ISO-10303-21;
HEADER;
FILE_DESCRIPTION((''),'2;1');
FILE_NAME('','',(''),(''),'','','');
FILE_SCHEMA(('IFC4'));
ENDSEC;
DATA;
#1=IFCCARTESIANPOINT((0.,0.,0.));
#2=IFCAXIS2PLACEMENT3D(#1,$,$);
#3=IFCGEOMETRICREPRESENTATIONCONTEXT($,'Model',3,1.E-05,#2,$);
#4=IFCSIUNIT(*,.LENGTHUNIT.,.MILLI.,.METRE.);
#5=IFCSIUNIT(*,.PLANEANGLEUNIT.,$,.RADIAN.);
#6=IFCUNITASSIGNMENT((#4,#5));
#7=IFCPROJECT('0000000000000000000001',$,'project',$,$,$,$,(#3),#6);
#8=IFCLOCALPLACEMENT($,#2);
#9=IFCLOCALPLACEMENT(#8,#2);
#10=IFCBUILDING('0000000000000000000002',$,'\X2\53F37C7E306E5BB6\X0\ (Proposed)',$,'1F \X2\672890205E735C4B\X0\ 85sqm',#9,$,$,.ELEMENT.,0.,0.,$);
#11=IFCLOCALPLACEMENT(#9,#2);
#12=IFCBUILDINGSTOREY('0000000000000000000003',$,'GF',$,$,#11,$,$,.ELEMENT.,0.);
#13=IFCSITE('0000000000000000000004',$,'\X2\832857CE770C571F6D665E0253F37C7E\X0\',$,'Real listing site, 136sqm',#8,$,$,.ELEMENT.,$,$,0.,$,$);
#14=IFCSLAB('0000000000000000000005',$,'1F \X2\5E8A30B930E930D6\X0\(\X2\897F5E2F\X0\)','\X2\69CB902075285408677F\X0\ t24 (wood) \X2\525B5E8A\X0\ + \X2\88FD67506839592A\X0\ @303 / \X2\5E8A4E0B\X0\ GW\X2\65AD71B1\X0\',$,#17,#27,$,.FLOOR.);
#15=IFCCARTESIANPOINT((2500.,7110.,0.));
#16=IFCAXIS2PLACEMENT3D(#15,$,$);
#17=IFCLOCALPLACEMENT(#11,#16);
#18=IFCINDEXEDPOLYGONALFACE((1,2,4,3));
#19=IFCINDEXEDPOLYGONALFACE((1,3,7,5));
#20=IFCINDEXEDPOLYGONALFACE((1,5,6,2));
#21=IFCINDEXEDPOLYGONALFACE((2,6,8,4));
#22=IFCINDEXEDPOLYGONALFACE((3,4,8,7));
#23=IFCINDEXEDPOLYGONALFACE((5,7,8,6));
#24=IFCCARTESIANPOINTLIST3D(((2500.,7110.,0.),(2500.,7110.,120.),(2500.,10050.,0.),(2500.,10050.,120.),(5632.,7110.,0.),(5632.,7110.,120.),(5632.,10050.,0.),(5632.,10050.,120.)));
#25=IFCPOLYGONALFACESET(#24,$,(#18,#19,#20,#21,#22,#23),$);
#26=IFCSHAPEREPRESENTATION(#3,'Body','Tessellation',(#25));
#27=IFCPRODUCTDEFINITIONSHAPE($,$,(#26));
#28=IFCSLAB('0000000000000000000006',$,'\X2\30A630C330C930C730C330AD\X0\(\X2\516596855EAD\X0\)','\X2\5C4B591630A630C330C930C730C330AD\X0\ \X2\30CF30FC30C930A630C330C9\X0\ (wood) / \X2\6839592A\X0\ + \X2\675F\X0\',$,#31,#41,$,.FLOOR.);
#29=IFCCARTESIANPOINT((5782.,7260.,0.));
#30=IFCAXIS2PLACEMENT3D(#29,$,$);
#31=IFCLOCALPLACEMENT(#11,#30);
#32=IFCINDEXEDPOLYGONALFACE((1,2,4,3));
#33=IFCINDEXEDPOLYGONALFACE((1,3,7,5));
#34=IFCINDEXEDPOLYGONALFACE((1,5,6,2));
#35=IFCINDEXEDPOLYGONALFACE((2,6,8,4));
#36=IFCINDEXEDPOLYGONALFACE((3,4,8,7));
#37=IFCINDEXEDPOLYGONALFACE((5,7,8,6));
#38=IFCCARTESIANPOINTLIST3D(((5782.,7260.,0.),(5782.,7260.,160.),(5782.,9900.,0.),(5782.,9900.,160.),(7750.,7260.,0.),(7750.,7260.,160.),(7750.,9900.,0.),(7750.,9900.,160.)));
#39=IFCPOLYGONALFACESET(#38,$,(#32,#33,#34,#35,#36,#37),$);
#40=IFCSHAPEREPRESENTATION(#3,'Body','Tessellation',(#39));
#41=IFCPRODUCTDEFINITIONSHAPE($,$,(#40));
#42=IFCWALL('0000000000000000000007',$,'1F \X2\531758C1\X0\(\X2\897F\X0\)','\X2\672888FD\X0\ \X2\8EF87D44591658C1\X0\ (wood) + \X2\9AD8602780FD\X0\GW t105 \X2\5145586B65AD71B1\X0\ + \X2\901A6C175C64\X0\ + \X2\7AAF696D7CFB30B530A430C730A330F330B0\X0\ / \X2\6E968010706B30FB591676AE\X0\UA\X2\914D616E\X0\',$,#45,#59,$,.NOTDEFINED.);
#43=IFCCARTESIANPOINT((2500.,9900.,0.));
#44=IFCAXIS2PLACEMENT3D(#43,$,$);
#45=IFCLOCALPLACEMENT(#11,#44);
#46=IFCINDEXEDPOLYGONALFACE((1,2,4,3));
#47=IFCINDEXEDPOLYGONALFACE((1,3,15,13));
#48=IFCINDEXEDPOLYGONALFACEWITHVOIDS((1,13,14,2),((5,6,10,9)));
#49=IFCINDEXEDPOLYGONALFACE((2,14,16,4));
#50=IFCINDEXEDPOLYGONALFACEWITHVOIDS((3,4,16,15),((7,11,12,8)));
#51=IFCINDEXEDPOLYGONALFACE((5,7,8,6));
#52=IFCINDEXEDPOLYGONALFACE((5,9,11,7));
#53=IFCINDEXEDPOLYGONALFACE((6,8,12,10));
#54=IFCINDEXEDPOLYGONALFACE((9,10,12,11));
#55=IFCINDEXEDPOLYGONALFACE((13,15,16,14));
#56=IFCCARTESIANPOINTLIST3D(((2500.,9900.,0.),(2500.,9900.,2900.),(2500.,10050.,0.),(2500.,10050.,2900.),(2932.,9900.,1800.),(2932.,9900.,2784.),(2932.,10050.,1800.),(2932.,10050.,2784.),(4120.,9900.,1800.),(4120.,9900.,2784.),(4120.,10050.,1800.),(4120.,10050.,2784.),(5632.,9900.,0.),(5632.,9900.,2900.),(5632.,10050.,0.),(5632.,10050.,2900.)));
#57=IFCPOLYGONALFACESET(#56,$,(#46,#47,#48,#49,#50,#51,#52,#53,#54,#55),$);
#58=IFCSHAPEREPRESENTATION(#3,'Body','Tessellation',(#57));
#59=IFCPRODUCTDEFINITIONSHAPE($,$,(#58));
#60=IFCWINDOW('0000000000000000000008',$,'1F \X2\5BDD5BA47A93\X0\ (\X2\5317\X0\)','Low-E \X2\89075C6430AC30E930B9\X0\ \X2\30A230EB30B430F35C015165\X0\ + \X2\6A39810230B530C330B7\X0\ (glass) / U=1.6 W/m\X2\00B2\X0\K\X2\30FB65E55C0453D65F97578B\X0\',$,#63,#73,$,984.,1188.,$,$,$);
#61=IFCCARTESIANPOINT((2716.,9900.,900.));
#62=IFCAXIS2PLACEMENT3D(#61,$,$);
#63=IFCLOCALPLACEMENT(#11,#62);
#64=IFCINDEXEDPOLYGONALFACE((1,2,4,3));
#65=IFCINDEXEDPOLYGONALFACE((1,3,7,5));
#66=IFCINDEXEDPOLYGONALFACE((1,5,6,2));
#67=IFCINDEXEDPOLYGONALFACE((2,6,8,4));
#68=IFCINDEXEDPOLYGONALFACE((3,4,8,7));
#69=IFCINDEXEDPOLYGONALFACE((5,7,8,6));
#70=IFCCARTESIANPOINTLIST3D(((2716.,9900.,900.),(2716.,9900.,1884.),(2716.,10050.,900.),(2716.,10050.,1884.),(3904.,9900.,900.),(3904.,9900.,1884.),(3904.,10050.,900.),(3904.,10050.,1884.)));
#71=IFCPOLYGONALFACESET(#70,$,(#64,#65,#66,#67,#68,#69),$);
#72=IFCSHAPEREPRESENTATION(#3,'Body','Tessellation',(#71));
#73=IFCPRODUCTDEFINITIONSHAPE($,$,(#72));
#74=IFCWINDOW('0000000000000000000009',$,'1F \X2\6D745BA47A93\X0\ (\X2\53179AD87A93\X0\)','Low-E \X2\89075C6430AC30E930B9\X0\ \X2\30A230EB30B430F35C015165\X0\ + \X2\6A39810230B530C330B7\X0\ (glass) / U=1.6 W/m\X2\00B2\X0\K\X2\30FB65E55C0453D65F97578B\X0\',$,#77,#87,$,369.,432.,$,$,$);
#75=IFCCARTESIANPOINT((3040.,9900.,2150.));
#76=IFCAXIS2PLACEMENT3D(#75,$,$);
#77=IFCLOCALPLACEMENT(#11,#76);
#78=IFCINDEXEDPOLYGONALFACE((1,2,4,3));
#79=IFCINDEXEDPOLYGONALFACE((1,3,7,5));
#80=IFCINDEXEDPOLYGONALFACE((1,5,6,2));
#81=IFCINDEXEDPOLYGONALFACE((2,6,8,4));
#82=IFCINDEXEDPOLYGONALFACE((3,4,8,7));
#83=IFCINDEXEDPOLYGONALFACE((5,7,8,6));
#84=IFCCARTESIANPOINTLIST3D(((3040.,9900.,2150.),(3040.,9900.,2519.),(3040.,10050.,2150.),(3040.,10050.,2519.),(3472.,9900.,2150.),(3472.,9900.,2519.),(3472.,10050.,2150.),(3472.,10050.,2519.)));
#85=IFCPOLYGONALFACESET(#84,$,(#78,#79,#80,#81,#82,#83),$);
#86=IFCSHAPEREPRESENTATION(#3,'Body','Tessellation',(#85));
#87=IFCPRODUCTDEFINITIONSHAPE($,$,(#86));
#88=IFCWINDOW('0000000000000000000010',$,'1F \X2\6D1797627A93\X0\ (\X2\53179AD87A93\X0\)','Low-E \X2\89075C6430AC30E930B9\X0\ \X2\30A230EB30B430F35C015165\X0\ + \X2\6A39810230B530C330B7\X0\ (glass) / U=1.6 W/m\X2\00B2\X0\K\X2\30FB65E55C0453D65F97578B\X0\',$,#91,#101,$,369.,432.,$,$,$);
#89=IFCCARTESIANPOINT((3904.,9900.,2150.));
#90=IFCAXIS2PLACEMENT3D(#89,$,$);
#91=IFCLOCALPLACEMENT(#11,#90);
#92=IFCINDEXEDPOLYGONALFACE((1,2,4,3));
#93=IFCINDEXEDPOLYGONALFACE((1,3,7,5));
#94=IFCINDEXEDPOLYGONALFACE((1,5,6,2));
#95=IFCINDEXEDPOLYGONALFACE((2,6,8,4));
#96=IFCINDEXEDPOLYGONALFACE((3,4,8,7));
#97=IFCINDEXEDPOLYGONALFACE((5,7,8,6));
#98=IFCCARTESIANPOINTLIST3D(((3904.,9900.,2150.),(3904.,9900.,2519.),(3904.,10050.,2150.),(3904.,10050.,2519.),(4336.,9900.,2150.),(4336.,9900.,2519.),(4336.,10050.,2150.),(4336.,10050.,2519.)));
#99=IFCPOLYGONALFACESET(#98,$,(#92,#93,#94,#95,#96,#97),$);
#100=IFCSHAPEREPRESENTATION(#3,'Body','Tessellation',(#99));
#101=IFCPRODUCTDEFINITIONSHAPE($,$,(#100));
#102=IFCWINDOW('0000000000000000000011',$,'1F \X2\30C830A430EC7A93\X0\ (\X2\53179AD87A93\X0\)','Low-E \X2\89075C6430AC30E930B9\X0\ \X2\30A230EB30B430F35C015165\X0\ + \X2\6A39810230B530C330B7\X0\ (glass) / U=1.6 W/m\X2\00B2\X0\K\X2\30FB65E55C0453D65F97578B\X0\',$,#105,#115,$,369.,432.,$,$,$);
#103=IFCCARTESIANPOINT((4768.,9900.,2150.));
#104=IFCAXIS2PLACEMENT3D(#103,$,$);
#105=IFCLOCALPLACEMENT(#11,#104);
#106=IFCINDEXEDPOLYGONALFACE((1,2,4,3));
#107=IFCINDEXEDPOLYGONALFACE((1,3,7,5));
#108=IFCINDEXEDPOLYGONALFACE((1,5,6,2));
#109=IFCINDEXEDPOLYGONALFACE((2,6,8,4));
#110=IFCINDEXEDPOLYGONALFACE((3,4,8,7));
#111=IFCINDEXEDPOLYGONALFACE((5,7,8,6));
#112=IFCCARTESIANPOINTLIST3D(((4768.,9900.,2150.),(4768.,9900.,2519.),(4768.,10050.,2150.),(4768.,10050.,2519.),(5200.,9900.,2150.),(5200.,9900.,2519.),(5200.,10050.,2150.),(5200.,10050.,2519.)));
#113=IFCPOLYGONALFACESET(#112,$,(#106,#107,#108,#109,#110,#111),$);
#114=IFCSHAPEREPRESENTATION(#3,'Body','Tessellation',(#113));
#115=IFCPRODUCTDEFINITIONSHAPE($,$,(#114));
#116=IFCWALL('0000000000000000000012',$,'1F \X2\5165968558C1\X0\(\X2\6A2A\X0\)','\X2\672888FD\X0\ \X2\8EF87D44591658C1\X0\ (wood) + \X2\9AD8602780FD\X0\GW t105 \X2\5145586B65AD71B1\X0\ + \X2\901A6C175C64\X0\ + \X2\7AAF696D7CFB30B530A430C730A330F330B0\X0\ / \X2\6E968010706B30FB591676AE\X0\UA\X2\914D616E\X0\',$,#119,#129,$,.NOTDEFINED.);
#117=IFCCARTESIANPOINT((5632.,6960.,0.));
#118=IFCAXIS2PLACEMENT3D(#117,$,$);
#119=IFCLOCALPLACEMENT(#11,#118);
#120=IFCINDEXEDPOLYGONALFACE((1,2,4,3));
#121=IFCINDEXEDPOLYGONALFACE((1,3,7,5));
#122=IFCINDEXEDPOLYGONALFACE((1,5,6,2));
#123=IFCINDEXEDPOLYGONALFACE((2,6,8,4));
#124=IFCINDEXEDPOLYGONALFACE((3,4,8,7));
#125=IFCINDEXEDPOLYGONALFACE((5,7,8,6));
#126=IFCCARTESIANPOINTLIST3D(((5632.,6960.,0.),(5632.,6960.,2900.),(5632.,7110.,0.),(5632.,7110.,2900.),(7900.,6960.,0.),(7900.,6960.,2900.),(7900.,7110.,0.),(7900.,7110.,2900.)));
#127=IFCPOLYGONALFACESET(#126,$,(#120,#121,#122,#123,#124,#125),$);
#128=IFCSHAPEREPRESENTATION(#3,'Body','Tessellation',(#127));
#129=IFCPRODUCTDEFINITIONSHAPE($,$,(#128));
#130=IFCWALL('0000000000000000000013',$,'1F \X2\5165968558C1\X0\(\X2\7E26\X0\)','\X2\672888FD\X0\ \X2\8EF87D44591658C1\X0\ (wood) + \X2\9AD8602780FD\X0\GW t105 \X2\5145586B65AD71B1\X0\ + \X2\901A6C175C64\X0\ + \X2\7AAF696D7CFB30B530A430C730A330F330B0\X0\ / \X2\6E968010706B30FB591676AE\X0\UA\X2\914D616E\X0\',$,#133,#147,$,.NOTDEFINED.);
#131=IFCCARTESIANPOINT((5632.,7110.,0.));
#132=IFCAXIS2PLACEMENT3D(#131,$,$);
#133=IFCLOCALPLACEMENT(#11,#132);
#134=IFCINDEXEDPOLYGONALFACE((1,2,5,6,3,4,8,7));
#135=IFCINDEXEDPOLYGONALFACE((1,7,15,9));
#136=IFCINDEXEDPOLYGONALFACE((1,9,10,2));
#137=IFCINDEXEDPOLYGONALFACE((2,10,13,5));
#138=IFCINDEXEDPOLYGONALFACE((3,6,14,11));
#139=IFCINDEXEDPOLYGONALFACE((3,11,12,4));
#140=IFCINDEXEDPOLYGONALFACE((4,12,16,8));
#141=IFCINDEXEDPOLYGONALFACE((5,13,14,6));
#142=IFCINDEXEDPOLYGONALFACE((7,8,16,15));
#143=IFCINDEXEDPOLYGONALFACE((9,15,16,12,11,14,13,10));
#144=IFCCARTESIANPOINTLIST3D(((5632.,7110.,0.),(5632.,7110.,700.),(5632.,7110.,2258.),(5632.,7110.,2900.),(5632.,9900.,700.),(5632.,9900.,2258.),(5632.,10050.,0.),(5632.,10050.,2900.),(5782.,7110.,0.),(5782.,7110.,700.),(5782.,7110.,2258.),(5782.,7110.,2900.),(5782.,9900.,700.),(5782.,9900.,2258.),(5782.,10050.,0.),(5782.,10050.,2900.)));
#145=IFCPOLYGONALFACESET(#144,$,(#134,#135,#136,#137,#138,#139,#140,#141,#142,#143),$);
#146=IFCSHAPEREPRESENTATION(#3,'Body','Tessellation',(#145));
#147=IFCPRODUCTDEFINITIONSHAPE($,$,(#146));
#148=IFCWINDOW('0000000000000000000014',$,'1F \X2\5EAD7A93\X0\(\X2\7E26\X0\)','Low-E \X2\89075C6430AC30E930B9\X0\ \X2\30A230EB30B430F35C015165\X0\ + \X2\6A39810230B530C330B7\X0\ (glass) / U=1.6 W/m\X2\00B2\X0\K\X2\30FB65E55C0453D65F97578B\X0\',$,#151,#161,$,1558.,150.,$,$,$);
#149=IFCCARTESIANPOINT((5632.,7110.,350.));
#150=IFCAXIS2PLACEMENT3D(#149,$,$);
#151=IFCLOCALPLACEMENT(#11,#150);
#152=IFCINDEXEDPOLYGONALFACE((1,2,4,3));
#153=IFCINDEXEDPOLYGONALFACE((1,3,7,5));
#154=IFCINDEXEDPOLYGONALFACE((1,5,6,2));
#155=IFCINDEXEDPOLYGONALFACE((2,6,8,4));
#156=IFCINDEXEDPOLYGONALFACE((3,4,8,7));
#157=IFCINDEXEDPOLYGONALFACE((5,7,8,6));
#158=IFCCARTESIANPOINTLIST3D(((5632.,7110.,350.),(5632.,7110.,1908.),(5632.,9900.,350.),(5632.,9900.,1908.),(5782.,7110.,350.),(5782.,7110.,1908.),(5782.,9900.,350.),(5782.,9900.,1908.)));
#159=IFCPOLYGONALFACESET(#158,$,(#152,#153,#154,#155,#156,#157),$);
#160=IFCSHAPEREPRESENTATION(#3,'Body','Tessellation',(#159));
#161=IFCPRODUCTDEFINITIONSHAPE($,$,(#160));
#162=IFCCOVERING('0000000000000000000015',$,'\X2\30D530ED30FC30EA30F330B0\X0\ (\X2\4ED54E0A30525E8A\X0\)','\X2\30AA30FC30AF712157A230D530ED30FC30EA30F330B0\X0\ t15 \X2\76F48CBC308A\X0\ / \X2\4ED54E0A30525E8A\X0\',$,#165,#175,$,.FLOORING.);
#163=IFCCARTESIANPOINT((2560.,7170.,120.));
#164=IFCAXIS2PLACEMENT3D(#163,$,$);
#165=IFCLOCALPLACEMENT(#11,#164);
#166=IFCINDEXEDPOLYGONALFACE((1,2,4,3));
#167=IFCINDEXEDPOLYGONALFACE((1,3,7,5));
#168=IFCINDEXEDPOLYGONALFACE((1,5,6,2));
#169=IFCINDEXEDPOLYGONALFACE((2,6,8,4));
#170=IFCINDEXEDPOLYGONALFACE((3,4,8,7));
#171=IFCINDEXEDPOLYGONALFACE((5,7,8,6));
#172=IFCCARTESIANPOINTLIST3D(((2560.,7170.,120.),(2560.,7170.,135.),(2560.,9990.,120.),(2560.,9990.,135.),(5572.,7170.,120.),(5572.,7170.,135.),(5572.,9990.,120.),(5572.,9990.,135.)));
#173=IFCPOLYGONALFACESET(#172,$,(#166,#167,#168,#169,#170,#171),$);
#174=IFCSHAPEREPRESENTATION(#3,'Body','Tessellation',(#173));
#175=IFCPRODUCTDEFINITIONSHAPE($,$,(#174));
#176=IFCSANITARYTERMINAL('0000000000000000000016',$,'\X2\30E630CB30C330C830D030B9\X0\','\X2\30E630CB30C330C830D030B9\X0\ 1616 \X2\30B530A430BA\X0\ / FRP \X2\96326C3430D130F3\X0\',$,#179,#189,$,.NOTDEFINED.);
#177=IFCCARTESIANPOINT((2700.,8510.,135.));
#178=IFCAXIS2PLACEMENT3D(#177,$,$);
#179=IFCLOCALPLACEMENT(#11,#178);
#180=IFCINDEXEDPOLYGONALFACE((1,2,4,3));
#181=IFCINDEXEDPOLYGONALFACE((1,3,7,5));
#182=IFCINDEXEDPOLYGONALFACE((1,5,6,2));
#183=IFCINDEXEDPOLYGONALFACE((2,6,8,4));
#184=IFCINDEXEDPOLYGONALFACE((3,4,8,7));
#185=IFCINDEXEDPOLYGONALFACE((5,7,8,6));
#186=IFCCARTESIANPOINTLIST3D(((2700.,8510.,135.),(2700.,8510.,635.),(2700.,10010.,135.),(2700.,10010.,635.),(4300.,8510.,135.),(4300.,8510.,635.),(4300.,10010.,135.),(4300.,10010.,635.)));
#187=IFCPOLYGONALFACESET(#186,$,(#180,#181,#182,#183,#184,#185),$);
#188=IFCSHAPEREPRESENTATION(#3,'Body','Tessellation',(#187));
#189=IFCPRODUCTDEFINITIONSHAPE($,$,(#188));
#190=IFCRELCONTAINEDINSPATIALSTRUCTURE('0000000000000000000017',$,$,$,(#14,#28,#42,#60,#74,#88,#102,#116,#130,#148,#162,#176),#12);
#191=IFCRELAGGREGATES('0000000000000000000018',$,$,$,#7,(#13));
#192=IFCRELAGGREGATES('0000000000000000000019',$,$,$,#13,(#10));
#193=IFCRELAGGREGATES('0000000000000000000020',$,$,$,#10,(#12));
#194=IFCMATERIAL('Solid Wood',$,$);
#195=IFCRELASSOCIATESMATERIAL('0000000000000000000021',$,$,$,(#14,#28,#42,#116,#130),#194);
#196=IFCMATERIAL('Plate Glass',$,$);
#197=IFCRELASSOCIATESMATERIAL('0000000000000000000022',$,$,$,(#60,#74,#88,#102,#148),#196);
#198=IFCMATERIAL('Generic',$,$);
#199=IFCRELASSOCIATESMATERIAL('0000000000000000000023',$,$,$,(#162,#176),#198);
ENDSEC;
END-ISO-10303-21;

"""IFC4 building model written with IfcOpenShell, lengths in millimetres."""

from ifc_helpers import new_model, si_unit, frame, frame_2d, origin, place, context, project, spatial, rectangle, extrude, material, element, fill, save


model = new_model("IFC4")

# Units and contexts
model_context = context("Model", 3, precision=1e-05, world=origin())
ifc_project = project(units=[si_unit("LENGTHUNIT", "METRE", prefix="MILLI"), si_unit("PLANEANGLEUNIT", "RADIAN")], contexts=[model_context])

# Site, building, storey
site_placement = place(None, origin())
site = spatial("IfcSite", under=ifc_project, at=site_placement, Name="茨城県土浦市右籾", ObjectType="Real listing site, 136sqm", CompositionType="ELEMENT", RefElevation=0.0)
building_placement = place(site_placement, origin())
building = spatial("IfcBuilding", under=site, at=building_placement, Name="右籾の家 (Proposed)", ObjectType="1F 木造平屋 85sqm", CompositionType="ELEMENT", ElevationOfRefHeight=0.0, ElevationOfTerrain=0.0)
storey_placement = place(building_placement, origin())
storey = spatial("IfcBuildingStorey", under=building, at=storey_placement, Name="GF", CompositionType="ELEMENT", Elevation=0.0)

# Slabs
ifc_material_1 = material(Name="Solid Wood")
slab_1_placement = place(storey_placement, frame((2500.0, 7110.0, 0.0)))
element("IfcSlab", 1, at=slab_1_placement, inside=storey, material=ifc_material_1, Name="1F 床スラブ(西帯)", Description="構造用合板 t24 (wood) 剛床 + 製材根太 @303 / 床下 GW断熱", PredefinedType="FLOOR", context=model_context, shape_type="SweptSolid", body=[
    extrude(rectangle(XDim=3132.0, YDim=2940.0, at=frame_2d((1566.0, 1470.0))), frame((2500.0, 7110.0, 0.0)), (0.0, 0.0, 1.0), 120.0),
])
slab_2_placement = place(storey_placement, frame((5782.0, 7260.0, 0.0)))
element("IfcSlab", 2, at=slab_2_placement, inside=storey, material=ifc_material_1, Name="ウッドデッキ(入隅庭)", Description="屋外ウッドデッキ ハードウッド (wood) / 根太 + 束", PredefinedType="FLOOR", context=model_context, shape_type="SweptSolid", body=[
    extrude(rectangle(XDim=1968.0, YDim=2640.0, at=frame_2d((984.0, 1320.0))), frame((5782.0, 7260.0, 0.0)), (0.0, 0.0, 1.0), 160.0),
])

# Wall, openings, windows
wall_1_placement = place(storey_placement, frame((2500.0, 9900.0, 0.0)))
wall_1 = element("IfcWall", 3, at=wall_1_placement, inside=storey, material=ifc_material_1, Name="1F 北壁(西)", Description="木製 軸組外壁 (wood) + 高性能GW t105 充填断熱 + 通気層 + 窯業系サイディング / 準耐火・外皮UA配慮", PredefinedType="NOTDEFINED", context=model_context, shape_type="SweptSolid", body=[
    extrude(rectangle(XDim=3132.0, YDim=150.0, at=frame_2d((1566.0, 75.0))), frame((2500.0, 9900.0, 0.0)), (0.0, 0.0, 1.0), 2900.0),
])
opening_1_placement = place(storey_placement, frame((2716.0, 9900.0, 900.0)))
opening_1 = element("IfcOpeningElement", 4, at=opening_1_placement, cuts=wall_1, PredefinedType="NOTDEFINED", context=model_context, shape_type="SweptSolid", body=[
    extrude(rectangle(XDim=1188.0, YDim=150.0, at=frame_2d((594.0, 75.0))), frame((2716.0, 9900.0, 900.0)), (0.0, 0.0, 1.0), 984.0),
])
opening_2_placement = place(storey_placement, frame((3040.0, 9900.0, 2150.0)))
opening_2 = element("IfcOpeningElement", 5, at=opening_2_placement, cuts=wall_1, PredefinedType="NOTDEFINED", context=model_context, shape_type="SweptSolid", body=[
    extrude(rectangle(XDim=432.0, YDim=150.0, at=frame_2d((216.0, 75.0))), frame((3040.0, 9900.0, 2150.0)), (0.0, 0.0, 1.0), 369.0),
])
opening_3_placement = place(storey_placement, frame((3904.0, 9900.0, 2150.0)))
opening_3 = element("IfcOpeningElement", 6, at=opening_3_placement, cuts=wall_1, PredefinedType="NOTDEFINED", context=model_context, shape_type="SweptSolid", body=[
    extrude(rectangle(XDim=432.0, YDim=150.0, at=frame_2d((216.0, 75.0))), frame((3904.0, 9900.0, 2150.0)), (0.0, 0.0, 1.0), 369.0),
])
opening_4_placement = place(storey_placement, frame((4768.0, 9900.0, 2150.0)))
opening_4 = element("IfcOpeningElement", 7, at=opening_4_placement, cuts=wall_1, PredefinedType="NOTDEFINED", context=model_context, shape_type="SweptSolid", body=[
    extrude(rectangle(XDim=432.0, YDim=150.0, at=frame_2d((216.0, 75.0))), frame((4768.0, 9900.0, 2150.0)), (0.0, 0.0, 1.0), 369.0),
])
ifc_material_2 = material(Name="Plate Glass")
window_1_placement = place(storey_placement, frame((2716.0, 9900.0, 900.0)))
window_1 = element("IfcWindow", 8, at=window_1_placement, inside=storey, material=ifc_material_2, Name="1F 寝室窓 (北)", Description="Low-E 複層ガラス アルゴン封入 + 樹脂サッシ (glass) / U=1.6 W/m²K・日射取得型", OverallHeight=984.0, OverallWidth=1188.0, context=model_context, shape_type="SweptSolid", body=[
    extrude(rectangle(XDim=1188.0, YDim=150.0, at=frame_2d((594.0, 75.0))), frame((2716.0, 9900.0, 900.0)), (0.0, 0.0, 1.0), 984.0),
])
fill(opening_1, window_1)
window_2_placement = place(storey_placement, frame((3040.0, 9900.0, 2150.0)))
window_2 = element("IfcWindow", 9, at=window_2_placement, inside=storey, material=ifc_material_2, Name="1F 浴室窓 (北高窓)", Description="Low-E 複層ガラス アルゴン封入 + 樹脂サッシ (glass) / U=1.6 W/m²K・日射取得型", OverallHeight=369.0, OverallWidth=432.0, context=model_context, shape_type="SweptSolid", body=[
    extrude(rectangle(XDim=432.0, YDim=150.0, at=frame_2d((216.0, 75.0))), frame((3040.0, 9900.0, 2150.0)), (0.0, 0.0, 1.0), 369.0),
])
fill(opening_2, window_2)
window_3_placement = place(storey_placement, frame((3904.0, 9900.0, 2150.0)))
window_3 = element("IfcWindow", 10, at=window_3_placement, inside=storey, material=ifc_material_2, Name="1F 洗面窓 (北高窓)", Description="Low-E 複層ガラス アルゴン封入 + 樹脂サッシ (glass) / U=1.6 W/m²K・日射取得型", OverallHeight=369.0, OverallWidth=432.0, context=model_context, shape_type="SweptSolid", body=[
    extrude(rectangle(XDim=432.0, YDim=150.0, at=frame_2d((216.0, 75.0))), frame((3904.0, 9900.0, 2150.0)), (0.0, 0.0, 1.0), 369.0),
])
fill(opening_3, window_3)
window_4_placement = place(storey_placement, frame((4768.0, 9900.0, 2150.0)))
window_4 = element("IfcWindow", 11, at=window_4_placement, inside=storey, material=ifc_material_2, Name="1F トイレ窓 (北高窓)", Description="Low-E 複層ガラス アルゴン封入 + 樹脂サッシ (glass) / U=1.6 W/m²K・日射取得型", OverallHeight=369.0, OverallWidth=432.0, context=model_context, shape_type="SweptSolid", body=[
    extrude(rectangle(XDim=432.0, YDim=150.0, at=frame_2d((216.0, 75.0))), frame((4768.0, 9900.0, 2150.0)), (0.0, 0.0, 1.0), 369.0),
])
fill(opening_4, window_4)

# Wall
wall_2_placement = place(storey_placement, frame((5632.0, 6960.0, 0.0)))
element("IfcWall", 12, at=wall_2_placement, inside=storey, material=ifc_material_1, Name="1F 入隅壁(横)", Description="木製 軸組外壁 (wood) + 高性能GW t105 充填断熱 + 通気層 + 窯業系サイディング / 準耐火・外皮UA配慮", PredefinedType="NOTDEFINED", context=model_context, shape_type="SweptSolid", body=[
    extrude(rectangle(XDim=2268.0, YDim=150.0, at=frame_2d((1134.0, 75.0))), frame((5632.0, 6960.0, 0.0)), (0.0, 0.0, 1.0), 2900.0),
])

# Wall, opening, window
wall_3_placement = place(storey_placement, frame((5632.0, 7110.0, 0.0)))
wall_3 = element("IfcWall", 13, at=wall_3_placement, inside=storey, material=ifc_material_1, Name="1F 入隅壁(縦)", Description="木製 軸組外壁 (wood) + 高性能GW t105 充填断熱 + 通気層 + 窯業系サイディング / 準耐火・外皮UA配慮", PredefinedType="NOTDEFINED", context=model_context, shape_type="SweptSolid", body=[
    extrude(rectangle(XDim=150.0, YDim=2940.0, at=frame_2d((75.0, 1470.0))), frame((5632.0, 7110.0, 0.0)), (0.0, 0.0, 1.0), 2900.0),
])
opening_5_placement = place(storey_placement, frame((5632.0, 7110.0, 350.0)))
opening_5 = element("IfcOpeningElement", 14, at=opening_5_placement, cuts=wall_3, PredefinedType="NOTDEFINED", context=model_context, shape_type="SweptSolid", body=[
    extrude(rectangle(XDim=150.0, YDim=2790.0, at=frame_2d((75.0, 1395.0))), frame((5632.0, 7110.0, 350.0)), (0.0, 0.0, 1.0), 1558.0),
])
window_5_placement = place(storey_placement, frame((5632.0, 7110.0, 350.0)))
window_5 = element("IfcWindow", 15, at=window_5_placement, inside=storey, material=ifc_material_2, Name="1F 庭窓(縦)", Description="Low-E 複層ガラス アルゴン封入 + 樹脂サッシ (glass) / U=1.6 W/m²K・日射取得型", OverallHeight=1558.0, OverallWidth=150.0, context=model_context, shape_type="SweptSolid", body=[
    extrude(rectangle(XDim=150.0, YDim=2790.0, at=frame_2d((75.0, 1395.0))), frame((5632.0, 7110.0, 350.0)), (0.0, 0.0, 1.0), 1558.0),
])
fill(opening_5, window_5)

# Covering
ifc_material_3 = material(Name="Generic")
covering_placement = place(storey_placement, frame((2560.0, 7170.0, 120.0)))
element("IfcCovering", 16, at=covering_placement, inside=storey, material=ifc_material_3, Name="フローリング (仕上げ床)", Description="オーク無垢フローリング t15 直貼り / 仕上げ床", PredefinedType="FLOORING", context=model_context, shape_type="SweptSolid", body=[
    extrude(rectangle(XDim=3012.0, YDim=2820.0, at=frame_2d((1506.0, 1410.0))), frame((2560.0, 7170.0, 120.0)), (0.0, 0.0, 1.0), 15.0),
])

# Sanitary terminal
sanitary_terminal_1_placement = place(storey_placement, frame((2700.0, 8510.0, 135.0)))
element("IfcSanitaryTerminal", 17, at=sanitary_terminal_1_placement, inside=storey, material=ifc_material_3, Name="ユニットバス", Description="ユニットバス 1616 サイズ / FRP 防水パン", PredefinedType="NOTDEFINED", context=model_context, shape_type="SweptSolid", body=[
    extrude(rectangle(XDim=1600.0, YDim=1500.0, at=frame_2d((800.0, 750.0))), frame((2700.0, 8510.0, 135.0)), (0.0, 0.0, 1.0), 500.0),
])

save(model, "model.ifc")
